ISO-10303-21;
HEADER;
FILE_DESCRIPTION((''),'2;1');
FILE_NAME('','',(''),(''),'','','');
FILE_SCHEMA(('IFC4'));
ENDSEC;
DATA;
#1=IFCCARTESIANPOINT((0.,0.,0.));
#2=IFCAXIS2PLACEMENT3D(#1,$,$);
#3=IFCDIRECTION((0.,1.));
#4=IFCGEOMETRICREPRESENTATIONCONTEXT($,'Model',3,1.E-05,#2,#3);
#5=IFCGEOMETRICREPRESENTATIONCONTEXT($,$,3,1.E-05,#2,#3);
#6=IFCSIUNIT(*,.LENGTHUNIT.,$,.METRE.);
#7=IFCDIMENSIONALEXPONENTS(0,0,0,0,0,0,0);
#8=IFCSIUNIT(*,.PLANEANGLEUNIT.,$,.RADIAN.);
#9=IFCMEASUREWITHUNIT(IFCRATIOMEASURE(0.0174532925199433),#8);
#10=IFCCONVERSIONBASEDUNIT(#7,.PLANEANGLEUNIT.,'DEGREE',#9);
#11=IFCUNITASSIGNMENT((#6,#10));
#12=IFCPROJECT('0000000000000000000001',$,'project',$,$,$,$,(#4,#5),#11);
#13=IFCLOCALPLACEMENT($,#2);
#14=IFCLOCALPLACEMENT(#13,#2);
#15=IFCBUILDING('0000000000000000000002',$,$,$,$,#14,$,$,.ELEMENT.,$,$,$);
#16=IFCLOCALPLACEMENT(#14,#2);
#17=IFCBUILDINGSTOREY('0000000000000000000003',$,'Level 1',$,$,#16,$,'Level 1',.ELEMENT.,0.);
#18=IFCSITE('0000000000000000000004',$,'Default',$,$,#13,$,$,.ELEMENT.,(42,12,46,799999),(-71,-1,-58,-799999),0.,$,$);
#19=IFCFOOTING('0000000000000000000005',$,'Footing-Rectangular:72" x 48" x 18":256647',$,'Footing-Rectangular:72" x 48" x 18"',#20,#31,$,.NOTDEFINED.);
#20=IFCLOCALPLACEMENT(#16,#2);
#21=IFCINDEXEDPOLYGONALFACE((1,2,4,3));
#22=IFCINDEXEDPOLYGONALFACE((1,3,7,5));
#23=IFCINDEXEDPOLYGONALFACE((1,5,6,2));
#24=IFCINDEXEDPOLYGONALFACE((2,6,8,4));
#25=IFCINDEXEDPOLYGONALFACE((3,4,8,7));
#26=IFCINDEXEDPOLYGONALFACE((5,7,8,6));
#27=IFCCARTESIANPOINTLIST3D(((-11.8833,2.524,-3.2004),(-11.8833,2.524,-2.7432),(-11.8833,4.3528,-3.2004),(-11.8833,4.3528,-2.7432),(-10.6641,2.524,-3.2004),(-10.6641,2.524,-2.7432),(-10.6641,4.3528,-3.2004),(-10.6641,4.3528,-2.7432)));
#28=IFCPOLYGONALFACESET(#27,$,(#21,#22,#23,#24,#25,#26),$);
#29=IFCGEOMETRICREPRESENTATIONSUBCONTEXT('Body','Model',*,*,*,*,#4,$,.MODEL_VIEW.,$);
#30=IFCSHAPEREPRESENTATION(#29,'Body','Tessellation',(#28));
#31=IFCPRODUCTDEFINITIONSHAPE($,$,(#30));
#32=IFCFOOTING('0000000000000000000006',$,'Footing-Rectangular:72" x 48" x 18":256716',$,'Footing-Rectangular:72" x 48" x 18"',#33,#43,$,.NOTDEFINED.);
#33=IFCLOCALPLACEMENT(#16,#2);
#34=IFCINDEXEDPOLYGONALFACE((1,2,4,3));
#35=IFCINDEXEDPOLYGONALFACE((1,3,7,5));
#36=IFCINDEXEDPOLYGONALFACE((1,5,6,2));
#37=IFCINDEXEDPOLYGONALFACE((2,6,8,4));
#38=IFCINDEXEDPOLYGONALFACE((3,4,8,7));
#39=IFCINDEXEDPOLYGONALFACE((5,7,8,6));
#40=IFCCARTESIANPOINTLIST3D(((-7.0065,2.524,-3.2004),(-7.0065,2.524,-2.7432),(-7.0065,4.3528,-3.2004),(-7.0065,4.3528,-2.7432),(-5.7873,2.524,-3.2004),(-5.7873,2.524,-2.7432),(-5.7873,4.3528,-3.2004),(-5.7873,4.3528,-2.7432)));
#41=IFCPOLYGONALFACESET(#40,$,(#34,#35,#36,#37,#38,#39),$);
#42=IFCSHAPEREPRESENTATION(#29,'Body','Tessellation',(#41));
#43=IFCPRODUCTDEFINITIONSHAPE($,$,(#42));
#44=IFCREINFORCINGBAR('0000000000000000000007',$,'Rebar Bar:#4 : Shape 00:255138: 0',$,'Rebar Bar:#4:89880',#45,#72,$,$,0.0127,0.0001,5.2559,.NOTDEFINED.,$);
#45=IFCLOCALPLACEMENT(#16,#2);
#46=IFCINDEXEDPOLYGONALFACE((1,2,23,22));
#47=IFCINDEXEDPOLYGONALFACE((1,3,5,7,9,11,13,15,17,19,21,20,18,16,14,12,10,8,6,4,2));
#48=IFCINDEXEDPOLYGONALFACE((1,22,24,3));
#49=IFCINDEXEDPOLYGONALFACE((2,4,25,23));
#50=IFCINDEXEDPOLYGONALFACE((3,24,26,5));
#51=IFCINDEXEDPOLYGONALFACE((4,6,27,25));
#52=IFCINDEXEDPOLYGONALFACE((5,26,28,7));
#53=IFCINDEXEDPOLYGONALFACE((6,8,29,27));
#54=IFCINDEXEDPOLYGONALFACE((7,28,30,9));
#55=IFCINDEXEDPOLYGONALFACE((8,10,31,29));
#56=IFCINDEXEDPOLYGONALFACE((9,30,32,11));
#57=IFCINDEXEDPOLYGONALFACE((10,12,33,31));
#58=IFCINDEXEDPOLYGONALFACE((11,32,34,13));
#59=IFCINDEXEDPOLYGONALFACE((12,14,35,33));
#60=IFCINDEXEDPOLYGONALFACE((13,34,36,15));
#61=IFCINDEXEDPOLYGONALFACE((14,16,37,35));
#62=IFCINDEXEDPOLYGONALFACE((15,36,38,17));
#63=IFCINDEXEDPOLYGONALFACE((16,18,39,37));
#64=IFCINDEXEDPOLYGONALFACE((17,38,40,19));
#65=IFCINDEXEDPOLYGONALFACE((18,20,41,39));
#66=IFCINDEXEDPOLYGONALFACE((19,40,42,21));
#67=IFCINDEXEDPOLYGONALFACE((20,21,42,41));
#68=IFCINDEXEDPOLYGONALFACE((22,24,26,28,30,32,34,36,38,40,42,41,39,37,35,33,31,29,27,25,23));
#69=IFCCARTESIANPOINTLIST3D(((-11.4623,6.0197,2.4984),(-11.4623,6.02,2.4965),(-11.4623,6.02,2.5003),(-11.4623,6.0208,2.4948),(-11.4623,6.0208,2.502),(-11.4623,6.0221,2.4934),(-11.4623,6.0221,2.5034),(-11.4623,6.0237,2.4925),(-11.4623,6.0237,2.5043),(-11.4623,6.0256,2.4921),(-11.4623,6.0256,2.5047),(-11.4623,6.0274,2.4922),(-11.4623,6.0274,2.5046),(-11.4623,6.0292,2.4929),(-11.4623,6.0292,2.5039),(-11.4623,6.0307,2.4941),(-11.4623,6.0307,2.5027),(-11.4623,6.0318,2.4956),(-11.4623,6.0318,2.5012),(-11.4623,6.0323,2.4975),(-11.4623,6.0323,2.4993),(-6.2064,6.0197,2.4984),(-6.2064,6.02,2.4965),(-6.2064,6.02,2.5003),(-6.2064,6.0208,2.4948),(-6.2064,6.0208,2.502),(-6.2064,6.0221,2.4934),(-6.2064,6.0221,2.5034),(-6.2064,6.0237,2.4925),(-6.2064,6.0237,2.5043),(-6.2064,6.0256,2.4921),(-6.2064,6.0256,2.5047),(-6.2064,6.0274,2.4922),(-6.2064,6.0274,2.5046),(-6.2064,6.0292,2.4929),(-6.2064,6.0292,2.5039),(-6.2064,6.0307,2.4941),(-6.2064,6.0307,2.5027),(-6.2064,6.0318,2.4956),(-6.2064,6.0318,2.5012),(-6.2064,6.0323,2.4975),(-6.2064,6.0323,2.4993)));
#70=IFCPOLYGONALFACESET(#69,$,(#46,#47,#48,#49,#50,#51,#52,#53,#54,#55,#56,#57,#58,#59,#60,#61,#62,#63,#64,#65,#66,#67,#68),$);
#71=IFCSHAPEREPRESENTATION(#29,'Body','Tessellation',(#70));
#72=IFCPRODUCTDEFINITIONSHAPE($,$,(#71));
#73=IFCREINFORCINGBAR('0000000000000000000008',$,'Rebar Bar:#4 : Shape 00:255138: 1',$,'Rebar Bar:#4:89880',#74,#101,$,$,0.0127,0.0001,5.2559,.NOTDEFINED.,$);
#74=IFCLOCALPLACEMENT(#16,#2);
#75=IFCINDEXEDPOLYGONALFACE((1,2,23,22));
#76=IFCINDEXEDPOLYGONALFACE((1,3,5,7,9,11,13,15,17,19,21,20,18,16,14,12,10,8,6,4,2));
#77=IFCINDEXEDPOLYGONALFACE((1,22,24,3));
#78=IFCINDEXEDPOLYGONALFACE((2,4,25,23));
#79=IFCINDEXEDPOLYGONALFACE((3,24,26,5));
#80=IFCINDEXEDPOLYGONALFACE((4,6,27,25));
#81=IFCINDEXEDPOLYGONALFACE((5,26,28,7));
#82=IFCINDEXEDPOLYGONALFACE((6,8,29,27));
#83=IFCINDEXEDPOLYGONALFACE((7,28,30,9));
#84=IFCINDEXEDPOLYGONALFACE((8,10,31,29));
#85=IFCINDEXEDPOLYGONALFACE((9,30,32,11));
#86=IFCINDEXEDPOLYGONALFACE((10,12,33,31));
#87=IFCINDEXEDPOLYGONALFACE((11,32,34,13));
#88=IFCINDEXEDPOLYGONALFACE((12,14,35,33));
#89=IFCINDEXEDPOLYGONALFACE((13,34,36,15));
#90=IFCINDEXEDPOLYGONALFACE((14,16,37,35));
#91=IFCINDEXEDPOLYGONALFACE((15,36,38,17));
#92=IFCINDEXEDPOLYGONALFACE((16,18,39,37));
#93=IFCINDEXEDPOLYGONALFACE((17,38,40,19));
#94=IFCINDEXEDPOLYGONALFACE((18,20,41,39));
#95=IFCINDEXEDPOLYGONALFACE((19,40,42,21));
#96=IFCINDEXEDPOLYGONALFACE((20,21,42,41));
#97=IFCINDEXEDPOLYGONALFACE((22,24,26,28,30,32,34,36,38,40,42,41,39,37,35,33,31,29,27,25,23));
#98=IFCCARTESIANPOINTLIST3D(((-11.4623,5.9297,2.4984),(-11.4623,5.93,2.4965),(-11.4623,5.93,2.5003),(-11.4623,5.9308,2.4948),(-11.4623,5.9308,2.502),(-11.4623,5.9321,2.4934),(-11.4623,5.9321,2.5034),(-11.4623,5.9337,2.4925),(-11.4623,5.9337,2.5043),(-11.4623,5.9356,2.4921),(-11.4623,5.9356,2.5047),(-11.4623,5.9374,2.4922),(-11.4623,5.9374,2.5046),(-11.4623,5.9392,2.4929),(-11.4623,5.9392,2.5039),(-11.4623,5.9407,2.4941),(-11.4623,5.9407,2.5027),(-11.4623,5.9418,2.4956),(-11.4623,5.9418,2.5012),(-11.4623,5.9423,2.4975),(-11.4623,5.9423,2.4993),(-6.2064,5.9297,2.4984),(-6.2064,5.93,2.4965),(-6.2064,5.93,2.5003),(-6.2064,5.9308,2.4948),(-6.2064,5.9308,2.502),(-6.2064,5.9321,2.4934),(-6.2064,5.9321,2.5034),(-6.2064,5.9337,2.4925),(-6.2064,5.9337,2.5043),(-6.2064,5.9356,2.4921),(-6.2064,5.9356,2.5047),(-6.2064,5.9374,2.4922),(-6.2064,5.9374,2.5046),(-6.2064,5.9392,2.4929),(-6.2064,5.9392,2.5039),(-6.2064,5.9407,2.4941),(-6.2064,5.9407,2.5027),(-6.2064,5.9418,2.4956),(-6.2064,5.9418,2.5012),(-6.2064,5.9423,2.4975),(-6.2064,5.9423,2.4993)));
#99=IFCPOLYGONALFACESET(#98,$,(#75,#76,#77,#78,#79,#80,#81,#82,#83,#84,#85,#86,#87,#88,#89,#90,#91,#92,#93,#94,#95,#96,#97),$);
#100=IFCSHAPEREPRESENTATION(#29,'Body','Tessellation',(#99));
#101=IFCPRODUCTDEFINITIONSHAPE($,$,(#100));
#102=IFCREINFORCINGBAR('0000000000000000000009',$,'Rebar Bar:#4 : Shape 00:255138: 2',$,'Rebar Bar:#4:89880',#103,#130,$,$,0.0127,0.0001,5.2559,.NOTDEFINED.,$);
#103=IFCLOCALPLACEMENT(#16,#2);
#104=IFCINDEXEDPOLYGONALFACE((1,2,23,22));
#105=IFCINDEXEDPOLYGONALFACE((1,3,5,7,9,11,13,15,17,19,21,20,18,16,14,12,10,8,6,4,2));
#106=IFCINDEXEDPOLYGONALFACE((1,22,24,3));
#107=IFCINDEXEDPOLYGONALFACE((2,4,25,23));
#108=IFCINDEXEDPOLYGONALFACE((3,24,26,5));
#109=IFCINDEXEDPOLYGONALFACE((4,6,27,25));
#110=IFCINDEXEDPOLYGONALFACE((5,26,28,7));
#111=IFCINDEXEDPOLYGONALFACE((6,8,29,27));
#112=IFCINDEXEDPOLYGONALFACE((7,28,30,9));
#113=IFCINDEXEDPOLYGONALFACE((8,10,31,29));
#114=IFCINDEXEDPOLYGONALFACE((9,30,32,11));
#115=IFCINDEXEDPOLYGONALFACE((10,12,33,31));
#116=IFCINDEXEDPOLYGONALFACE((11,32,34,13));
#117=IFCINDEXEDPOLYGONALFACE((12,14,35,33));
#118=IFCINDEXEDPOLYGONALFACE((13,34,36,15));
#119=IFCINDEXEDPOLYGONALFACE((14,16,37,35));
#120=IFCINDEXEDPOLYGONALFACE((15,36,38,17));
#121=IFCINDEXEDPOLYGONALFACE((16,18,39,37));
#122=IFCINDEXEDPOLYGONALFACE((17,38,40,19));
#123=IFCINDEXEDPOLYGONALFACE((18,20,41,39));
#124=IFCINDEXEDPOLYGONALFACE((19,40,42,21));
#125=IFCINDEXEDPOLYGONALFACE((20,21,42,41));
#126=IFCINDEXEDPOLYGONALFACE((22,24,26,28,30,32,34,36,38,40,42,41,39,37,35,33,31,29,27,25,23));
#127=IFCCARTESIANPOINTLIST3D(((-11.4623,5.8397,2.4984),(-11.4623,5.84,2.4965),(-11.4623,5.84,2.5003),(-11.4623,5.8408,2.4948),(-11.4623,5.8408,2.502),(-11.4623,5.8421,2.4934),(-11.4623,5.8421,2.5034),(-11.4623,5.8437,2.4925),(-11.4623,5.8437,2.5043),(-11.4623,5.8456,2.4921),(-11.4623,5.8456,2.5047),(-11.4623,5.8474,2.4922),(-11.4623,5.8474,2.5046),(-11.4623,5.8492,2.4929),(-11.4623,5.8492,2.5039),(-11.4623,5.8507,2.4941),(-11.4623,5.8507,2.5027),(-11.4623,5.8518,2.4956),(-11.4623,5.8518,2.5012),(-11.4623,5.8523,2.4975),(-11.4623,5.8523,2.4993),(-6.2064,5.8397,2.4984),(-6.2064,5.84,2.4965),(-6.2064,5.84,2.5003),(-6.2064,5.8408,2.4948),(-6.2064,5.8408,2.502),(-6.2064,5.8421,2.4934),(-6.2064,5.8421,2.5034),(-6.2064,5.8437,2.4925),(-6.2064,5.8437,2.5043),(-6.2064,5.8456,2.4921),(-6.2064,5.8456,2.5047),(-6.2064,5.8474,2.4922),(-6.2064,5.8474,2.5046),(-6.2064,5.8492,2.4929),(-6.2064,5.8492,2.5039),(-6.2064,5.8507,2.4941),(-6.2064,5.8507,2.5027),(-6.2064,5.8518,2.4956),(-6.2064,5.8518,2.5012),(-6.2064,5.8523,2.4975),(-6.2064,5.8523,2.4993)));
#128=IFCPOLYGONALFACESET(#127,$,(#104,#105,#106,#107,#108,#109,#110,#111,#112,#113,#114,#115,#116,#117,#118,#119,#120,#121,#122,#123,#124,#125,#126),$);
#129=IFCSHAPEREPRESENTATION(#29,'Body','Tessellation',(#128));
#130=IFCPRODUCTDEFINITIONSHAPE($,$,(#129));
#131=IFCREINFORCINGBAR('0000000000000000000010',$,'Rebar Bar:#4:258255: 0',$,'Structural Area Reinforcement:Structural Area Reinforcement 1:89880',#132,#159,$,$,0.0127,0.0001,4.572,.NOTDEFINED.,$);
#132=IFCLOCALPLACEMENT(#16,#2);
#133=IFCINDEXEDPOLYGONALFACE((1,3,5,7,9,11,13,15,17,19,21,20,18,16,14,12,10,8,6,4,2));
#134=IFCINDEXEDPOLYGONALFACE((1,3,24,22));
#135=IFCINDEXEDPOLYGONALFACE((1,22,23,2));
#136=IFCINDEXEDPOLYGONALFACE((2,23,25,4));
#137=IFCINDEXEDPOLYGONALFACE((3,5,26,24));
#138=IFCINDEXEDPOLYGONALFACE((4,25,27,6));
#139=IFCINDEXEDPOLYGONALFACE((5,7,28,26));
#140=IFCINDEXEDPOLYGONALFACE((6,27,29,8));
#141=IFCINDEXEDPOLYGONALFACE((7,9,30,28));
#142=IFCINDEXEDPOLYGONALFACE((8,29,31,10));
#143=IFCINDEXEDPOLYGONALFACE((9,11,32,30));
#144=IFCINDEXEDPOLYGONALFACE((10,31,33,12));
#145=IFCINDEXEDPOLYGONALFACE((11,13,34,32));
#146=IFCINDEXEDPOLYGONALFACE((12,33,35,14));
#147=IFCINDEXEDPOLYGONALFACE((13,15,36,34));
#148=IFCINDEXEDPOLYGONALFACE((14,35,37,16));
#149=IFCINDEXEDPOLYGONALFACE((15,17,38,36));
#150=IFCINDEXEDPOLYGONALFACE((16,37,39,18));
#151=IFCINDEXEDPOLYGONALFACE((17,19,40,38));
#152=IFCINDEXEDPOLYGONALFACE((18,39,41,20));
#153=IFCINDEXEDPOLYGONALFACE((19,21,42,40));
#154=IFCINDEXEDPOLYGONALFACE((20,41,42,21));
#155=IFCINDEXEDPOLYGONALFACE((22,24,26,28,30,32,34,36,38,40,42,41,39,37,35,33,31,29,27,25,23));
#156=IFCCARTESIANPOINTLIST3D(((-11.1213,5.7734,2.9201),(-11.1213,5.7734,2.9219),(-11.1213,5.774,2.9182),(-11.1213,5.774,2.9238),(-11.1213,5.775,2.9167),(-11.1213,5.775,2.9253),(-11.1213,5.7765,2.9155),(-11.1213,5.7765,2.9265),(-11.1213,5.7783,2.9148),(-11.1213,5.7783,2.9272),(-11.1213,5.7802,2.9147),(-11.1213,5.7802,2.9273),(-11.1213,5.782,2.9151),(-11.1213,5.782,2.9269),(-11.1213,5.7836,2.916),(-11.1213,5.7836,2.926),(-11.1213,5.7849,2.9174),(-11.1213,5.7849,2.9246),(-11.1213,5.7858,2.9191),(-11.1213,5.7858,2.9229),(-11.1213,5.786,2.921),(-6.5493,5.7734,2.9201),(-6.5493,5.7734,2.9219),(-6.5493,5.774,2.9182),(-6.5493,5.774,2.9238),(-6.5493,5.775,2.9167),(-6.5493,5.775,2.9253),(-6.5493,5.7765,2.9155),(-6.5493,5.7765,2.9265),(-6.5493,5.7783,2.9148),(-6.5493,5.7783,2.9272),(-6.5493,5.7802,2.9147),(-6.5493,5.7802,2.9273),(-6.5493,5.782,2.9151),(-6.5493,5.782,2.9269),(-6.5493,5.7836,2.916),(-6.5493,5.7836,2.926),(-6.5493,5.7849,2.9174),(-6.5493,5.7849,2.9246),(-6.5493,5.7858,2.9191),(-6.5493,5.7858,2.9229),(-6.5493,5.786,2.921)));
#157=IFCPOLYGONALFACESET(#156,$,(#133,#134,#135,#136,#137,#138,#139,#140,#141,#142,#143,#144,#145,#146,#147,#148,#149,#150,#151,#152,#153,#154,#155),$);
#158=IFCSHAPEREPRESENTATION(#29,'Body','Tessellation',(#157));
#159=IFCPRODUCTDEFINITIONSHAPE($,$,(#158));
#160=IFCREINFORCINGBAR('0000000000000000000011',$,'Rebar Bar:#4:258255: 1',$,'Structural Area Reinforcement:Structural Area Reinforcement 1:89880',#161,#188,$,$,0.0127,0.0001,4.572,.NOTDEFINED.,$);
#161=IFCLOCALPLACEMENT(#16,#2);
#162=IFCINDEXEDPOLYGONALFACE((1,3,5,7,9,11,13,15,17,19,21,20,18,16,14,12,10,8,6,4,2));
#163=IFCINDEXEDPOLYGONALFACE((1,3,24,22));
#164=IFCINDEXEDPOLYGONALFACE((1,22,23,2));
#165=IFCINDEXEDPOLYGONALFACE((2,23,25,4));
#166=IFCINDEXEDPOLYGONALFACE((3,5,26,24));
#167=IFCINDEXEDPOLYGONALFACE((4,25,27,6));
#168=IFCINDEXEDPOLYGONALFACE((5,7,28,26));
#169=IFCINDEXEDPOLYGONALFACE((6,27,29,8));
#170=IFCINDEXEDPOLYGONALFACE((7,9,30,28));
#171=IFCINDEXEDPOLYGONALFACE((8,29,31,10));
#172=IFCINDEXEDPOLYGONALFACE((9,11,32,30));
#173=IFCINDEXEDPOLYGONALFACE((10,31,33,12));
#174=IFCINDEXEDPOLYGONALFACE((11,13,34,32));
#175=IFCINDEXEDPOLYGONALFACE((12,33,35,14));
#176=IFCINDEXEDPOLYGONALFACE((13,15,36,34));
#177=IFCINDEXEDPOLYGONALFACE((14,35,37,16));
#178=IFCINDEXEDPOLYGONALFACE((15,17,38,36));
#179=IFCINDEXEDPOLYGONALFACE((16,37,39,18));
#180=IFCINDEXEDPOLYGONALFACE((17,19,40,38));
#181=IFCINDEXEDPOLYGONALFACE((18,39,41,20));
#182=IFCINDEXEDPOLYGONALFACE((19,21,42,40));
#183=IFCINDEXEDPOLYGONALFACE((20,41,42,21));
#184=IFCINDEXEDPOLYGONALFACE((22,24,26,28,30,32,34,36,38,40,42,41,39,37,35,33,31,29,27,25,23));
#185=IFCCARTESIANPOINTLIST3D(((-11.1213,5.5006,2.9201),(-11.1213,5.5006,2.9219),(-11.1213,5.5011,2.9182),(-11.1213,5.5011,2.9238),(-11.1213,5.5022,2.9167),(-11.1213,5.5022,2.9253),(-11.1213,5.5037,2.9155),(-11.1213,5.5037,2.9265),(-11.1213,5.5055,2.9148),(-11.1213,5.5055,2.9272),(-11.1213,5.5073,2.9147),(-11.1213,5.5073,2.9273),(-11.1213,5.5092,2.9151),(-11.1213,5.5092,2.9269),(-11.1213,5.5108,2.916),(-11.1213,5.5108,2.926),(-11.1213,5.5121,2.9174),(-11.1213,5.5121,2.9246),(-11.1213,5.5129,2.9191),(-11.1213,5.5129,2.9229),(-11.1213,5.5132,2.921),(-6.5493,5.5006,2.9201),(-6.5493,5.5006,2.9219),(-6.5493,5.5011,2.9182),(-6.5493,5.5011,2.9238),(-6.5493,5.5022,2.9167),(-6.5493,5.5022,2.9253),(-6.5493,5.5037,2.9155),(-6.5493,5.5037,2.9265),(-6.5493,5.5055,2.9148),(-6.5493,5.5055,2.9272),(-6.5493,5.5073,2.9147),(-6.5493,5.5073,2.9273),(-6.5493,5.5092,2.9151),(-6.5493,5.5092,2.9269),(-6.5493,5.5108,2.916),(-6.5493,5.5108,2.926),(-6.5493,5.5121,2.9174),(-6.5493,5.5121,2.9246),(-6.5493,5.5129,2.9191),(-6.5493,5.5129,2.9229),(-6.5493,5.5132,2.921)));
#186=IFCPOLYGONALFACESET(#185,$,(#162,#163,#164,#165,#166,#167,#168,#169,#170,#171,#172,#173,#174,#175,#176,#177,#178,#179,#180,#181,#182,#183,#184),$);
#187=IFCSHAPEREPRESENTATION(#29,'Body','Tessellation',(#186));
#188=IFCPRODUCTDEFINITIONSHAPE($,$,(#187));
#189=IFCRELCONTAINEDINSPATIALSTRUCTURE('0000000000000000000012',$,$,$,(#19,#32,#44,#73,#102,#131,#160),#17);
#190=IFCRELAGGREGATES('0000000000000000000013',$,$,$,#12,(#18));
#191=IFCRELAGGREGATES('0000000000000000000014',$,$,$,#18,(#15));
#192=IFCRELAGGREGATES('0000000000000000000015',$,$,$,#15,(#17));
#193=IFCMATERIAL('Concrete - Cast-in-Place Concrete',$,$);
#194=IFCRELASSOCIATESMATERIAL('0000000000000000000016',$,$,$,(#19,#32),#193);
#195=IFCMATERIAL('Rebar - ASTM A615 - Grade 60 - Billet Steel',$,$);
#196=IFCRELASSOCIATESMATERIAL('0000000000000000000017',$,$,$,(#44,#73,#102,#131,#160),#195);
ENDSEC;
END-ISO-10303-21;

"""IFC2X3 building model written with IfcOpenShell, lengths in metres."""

from ifc_helpers import new_model, entity, si_unit, converted_unit, direction, frame, frame_2d, origin, origin_2d_with_axis, place, context, subcontext, project, spatial, rectangle, extrude, material, element, save


model = new_model("IFC2X3")

# Units and contexts
model_context = context("Model", 3, precision=1e-05, world=origin(), true_north=direction((0.0, 1.0)))
context_of_model = context(None, 3, precision=1e-05, world=origin(), true_north=direction((0.0, 1.0)))
body_context = subcontext(model_context, "Body", "Model", "MODEL_VIEW")
ifc_project = project(units=[si_unit("LENGTHUNIT", "METRE"), converted_unit("PLANEANGLEUNIT", "DEGREE", entity("IfcRatioMeasure", 0.0174532925199433), si_unit("PLANEANGLEUNIT", "RADIAN"), dimensions=[0, 0, 0, 0, 0, 0, 0])], contexts=[model_context, context_of_model])

# Site, building, storey
site_placement = place(None, origin())
site = spatial("IfcSite", under=ifc_project, at=site_placement, Name="Default", CompositionType="ELEMENT", RefLatitude=(42, 12, 46, 799999), RefLongitude=(-71, -1, -58, -799999), RefElevation=0.0)
building_placement = place(site_placement, origin())
building = spatial("IfcBuilding", under=site, at=building_placement, CompositionType="ELEMENT")
storey_placement = place(building_placement, origin())
storey = spatial("IfcBuildingStorey", under=building, at=storey_placement, Name="Level 1", LongName="Level 1", CompositionType="ELEMENT", Elevation=0.0)

# Footings
ifc_material_1 = material(Name="Concrete - Cast-in-Place Concrete")
footing_1_placement = place(storey_placement, origin())
element("IfcFooting", 1, at=footing_1_placement, inside=storey, material=ifc_material_1, Name="Footing-Rectangular:72\" x 48\" x 18\":256647", ObjectType="Footing-Rectangular:72\" x 48\" x 18\"", PredefinedType="NOTDEFINED", context=body_context, shape_type="SweptSolid", body=[
    extrude(rectangle(XDim=1.2192, YDim=1.8288, at=origin_2d_with_axis()), frame((-11.2737, 3.4384, -3.2004), z_axis=(0.0, 0.0, 1.0), x_axis=(-1.0, 0.0, 0.0)), (0.0, 0.0, 1.0), 0.4572),
])
footing_2_placement = place(storey_placement, origin())
element("IfcFooting", 2, at=footing_2_placement, inside=storey, material=ifc_material_1, Name="Footing-Rectangular:72\" x 48\" x 18\":256716", ObjectType="Footing-Rectangular:72\" x 48\" x 18\"", PredefinedType="NOTDEFINED", context=body_context, shape_type="SweptSolid", body=[
    extrude(rectangle(XDim=1.2192, YDim=1.8288, at=frame_2d((0.0, 0.0), x_axis=(1.0, 0.0))), frame((-6.3969, 3.4384, -3.2004), z_axis=(0.0, 0.0, 1.0), x_axis=(-1.0, 0.0, 0.0)), (0.0, 0.0, 1.0), 0.4572),
])

# Reinforcing bars
ifc_material_2 = material(Name="Rebar - ASTM A615 - Grade 60 - Billet Steel")
reinforcing_bar_1_placement = place(storey_placement, origin())
element("IfcReinforcingBar", 3, at=reinforcing_bar_1_placement, inside=storey, material=ifc_material_2, Name="Rebar Bar:#4 : Shape 00:255138: 0", ObjectType="Rebar Bar:#4:89880", BarLength=5.2559, BarRole="NOTDEFINED", CrossSectionArea=0.0001, NominalDiameter=0.0127, context=body_context, shape_type="AdvancedSweptSolid", body=[
    entity("IfcSweptDiskSolid", entity("IfcCompositeCurve", [entity("IfcCompositeCurveSegment", "CONTINUOUS", True, entity("IfcPolyline", [entity("IfcCartesianPoint", [-6.2064, 6.026, 2.4984]), entity("IfcCartesianPoint", [-11.4623, 6.026, 2.4984])]))], False), 0.0063, None, 0.0, 1.0),
])
reinforcing_bar_2_placement = place(storey_placement, origin())
element("IfcReinforcingBar", 4, at=reinforcing_bar_2_placement, inside=storey, material=ifc_material_2, Name="Rebar Bar:#4 : Shape 00:255138: 1", ObjectType="Rebar Bar:#4:89880", BarLength=5.2559, BarRole="NOTDEFINED", CrossSectionArea=0.0001, NominalDiameter=0.0127, context=body_context, shape_type="AdvancedSweptSolid", body=[
    entity("IfcSweptDiskSolid", entity("IfcCompositeCurve", [entity("IfcCompositeCurveSegment", "CONTINUOUS", True, entity("IfcPolyline", [entity("IfcCartesianPoint", [-6.2064, 5.936, 2.4984]), entity("IfcCartesianPoint", [-11.4623, 5.936, 2.4984])]))], False), 0.0063, None, 0.0, 1.0),
])
reinforcing_bar_3_placement = place(storey_placement, origin())
element("IfcReinforcingBar", 5, at=reinforcing_bar_3_placement, inside=storey, material=ifc_material_2, Name="Rebar Bar:#4 : Shape 00:255138: 2", ObjectType="Rebar Bar:#4:89880", BarLength=5.2559, BarRole="NOTDEFINED", CrossSectionArea=0.0001, NominalDiameter=0.0127, context=body_context, shape_type="AdvancedSweptSolid", body=[
    entity("IfcSweptDiskSolid", entity("IfcCompositeCurve", [entity("IfcCompositeCurveSegment", "CONTINUOUS", True, entity("IfcPolyline", [entity("IfcCartesianPoint", [-6.2064, 5.846, 2.4984]), entity("IfcCartesianPoint", [-11.4623, 5.846, 2.4984])]))], False), 0.0063, None, 0.0, 1.0),
])
reinforcing_bar_4_placement = place(storey_placement, origin())
element("IfcReinforcingBar", 6, at=reinforcing_bar_4_placement, inside=storey, material=ifc_material_2, Name="Rebar Bar:#4:258255: 0", ObjectType="Structural Area Reinforcement:Structural Area Reinforcement 1:89880", BarLength=4.572, BarRole="NOTDEFINED", CrossSectionArea=0.0001, NominalDiameter=0.0127, context=body_context, shape_type="AdvancedSweptSolid", body=[
    entity("IfcSweptDiskSolid", entity("IfcCompositeCurve", [entity("IfcCompositeCurveSegment", "CONTINUOUS", True, entity("IfcPolyline", [entity("IfcCartesianPoint", [-11.1213, 5.7797, 2.921]), entity("IfcCartesianPoint", [-6.5493, 5.7797, 2.921])]))], False), 0.0063, None, 0.0, 1.0),
])
reinforcing_bar_5_placement = place(storey_placement, origin())
element("IfcReinforcingBar", 7, at=reinforcing_bar_5_placement, inside=storey, material=ifc_material_2, Name="Rebar Bar:#4:258255: 1", ObjectType="Structural Area Reinforcement:Structural Area Reinforcement 1:89880", BarLength=4.572, BarRole="NOTDEFINED", CrossSectionArea=0.0001, NominalDiameter=0.0127, context=body_context, shape_type="AdvancedSweptSolid", body=[
    entity("IfcSweptDiskSolid", entity("IfcCompositeCurve", [entity("IfcCompositeCurveSegment", "CONTINUOUS", True, entity("IfcPolyline", [entity("IfcCartesianPoint", [-11.1213, 5.5069, 2.921]), entity("IfcCartesianPoint", [-6.5493, 5.5069, 2.921])]))], False), 0.0063, None, 0.0, 1.0),
])

save(model, "model.ifc")
